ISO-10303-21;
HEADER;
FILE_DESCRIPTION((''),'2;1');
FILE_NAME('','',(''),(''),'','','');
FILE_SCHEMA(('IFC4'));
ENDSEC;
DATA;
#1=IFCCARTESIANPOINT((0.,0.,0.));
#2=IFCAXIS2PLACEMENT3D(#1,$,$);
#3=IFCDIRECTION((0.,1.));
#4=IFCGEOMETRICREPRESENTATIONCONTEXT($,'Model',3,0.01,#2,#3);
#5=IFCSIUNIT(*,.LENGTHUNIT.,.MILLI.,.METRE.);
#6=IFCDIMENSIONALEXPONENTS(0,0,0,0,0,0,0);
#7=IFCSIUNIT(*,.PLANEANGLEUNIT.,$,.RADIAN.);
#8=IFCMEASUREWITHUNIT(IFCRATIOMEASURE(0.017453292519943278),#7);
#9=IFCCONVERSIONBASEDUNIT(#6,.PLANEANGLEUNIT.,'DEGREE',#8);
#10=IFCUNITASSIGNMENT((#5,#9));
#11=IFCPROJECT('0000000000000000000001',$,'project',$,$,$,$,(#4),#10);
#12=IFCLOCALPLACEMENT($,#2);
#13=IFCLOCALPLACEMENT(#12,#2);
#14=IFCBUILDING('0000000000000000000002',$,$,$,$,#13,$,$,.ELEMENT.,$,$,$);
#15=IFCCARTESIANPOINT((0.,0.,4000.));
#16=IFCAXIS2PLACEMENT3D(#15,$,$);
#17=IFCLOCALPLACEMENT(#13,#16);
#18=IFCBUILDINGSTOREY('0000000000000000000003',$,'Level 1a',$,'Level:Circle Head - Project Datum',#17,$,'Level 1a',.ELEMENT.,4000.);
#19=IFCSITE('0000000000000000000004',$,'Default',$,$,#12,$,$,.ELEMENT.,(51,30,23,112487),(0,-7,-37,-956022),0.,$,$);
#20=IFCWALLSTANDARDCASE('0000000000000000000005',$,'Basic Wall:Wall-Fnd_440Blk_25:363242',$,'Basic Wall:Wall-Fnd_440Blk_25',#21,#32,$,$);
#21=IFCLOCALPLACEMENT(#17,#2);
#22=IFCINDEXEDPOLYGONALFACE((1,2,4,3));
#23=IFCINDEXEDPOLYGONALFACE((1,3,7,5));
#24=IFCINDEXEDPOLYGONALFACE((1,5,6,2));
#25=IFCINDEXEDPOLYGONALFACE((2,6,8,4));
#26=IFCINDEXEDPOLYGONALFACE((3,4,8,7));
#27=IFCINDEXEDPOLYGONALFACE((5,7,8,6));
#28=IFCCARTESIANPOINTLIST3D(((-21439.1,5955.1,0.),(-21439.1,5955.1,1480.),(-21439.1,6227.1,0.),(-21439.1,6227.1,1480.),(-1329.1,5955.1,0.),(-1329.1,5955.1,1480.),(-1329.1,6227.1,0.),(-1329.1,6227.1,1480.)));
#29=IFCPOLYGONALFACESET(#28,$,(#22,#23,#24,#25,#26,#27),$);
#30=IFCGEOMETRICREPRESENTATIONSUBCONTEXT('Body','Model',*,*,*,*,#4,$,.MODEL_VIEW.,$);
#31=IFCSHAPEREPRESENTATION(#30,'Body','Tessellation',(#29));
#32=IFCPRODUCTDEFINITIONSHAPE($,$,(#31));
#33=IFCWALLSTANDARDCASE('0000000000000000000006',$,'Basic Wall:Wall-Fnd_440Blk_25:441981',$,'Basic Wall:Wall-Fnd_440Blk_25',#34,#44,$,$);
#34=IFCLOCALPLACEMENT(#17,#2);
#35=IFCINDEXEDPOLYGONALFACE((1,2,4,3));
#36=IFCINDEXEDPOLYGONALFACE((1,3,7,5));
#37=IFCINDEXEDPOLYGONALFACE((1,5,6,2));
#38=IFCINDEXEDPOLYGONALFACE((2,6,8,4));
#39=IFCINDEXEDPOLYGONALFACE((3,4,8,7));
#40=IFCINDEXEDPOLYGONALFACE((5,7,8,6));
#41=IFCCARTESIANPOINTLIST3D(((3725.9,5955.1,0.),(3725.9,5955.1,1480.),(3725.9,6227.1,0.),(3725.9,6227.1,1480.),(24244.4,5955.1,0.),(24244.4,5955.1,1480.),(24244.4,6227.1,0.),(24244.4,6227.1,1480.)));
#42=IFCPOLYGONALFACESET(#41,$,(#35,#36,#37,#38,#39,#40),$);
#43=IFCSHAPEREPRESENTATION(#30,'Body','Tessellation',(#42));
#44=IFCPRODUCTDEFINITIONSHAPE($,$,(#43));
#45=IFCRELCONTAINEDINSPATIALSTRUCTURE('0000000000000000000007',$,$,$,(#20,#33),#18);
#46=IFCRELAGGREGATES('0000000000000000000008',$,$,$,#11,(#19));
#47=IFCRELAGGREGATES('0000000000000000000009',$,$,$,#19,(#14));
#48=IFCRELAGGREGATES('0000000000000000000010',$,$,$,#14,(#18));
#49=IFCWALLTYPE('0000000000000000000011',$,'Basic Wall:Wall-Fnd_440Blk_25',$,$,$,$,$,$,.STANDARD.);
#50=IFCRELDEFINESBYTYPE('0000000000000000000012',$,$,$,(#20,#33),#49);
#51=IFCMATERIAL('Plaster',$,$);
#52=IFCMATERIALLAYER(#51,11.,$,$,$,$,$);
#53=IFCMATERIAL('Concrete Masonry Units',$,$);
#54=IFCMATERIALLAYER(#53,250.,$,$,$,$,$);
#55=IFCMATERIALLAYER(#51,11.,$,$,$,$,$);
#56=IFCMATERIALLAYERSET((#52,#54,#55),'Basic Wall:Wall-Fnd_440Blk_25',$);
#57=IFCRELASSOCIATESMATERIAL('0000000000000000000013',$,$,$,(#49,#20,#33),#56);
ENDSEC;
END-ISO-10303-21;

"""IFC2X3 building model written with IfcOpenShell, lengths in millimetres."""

from ifc_helpers import new_model, entity, si_unit, converted_unit, direction, frame, frame_2d, origin, place, context, subcontext, project, spatial, rectangle, extrude, material, layer, layer_set, layer_usage, type_object, element, save


model = new_model("IFC2X3")

# Units and contexts
model_context = context("Model", 3, precision=0.01, world=origin(), true_north=direction((0.0, 1.0)))
body_context = subcontext(model_context, "Body", "Model", "MODEL_VIEW")
ifc_project = project(units=[si_unit("LENGTHUNIT", "METRE", prefix="MILLI"), converted_unit("PLANEANGLEUNIT", "DEGREE", entity("IfcRatioMeasure", 0.017453292519943278), si_unit("PLANEANGLEUNIT", "RADIAN"), dimensions=[0, 0, 0, 0, 0, 0, 0])], contexts=[model_context])

# Site, building, storey
site_placement = place(None, origin())
site = spatial("IfcSite", under=ifc_project, at=site_placement, Name="Default", CompositionType="ELEMENT", RefLatitude=(51, 30, 23, 112487), RefLongitude=(0, -7, -37, -956022), RefElevation=0.0)
building_placement = place(site_placement, origin())
building = spatial("IfcBuilding", under=site, at=building_placement, CompositionType="ELEMENT")
storey_placement = place(building_placement, frame((0.0, 0.0, 4000.0)))
storey = spatial("IfcBuildingStorey", under=building, at=storey_placement, Name="Level 1a", ObjectType="Level:Circle Head - Project Datum", LongName="Level 1a", CompositionType="ELEMENT", Elevation=4000.0)

# Walls
ifc_material_1 = material(Name="Plaster")
ifc_layer_1 = layer(ifc_material_1, 11.0)
ifc_material_2 = material(Name="Concrete Masonry Units")
ifc_layer_2 = layer(ifc_material_2, 250.0)
ifc_layer_3 = layer(ifc_material_1, 11.0)
ifc_layer_set = layer_set([ifc_layer_1, ifc_layer_2, ifc_layer_3], Name="Basic Wall:Wall-Fnd_440Blk_25")
ifc_layer_usage_1 = layer_usage(ifc_layer_set, "AXIS2", "NEGATIVE", 136.0)
wall_type = type_object("IfcWallType", Name="Basic Wall:Wall-Fnd_440Blk_25", PredefinedType="STANDARD", material=ifc_layer_set)
wall_1_placement = place(storey_placement, frame((-1329.1, 6091.1, 0.0), z_axis=(0.0, 0.0, 1.0), x_axis=(-1.0, 0.0, 0.0)))
element("IfcWallStandardCase", 1, at=wall_1_placement, inside=storey, type_object=wall_type, material=ifc_layer_usage_1, Name="Basic Wall:Wall-Fnd_440Blk_25:363242", ObjectType="Basic Wall:Wall-Fnd_440Blk_25", context=body_context, shape_type="SweptSolid", body=[
    extrude(rectangle(XDim=20110.0, YDim=272.0, at=frame_2d((10055.0, 0.0), x_axis=(-1.0, 0.0))), origin(), (0.0, 0.0, 1.0), 1480.0),
])
ifc_layer_usage_2 = layer_usage(ifc_layer_set, "AXIS2", "NEGATIVE", 136.0)
wall_2_placement = place(storey_placement, frame((24244.4, 6091.1, 0.0), z_axis=(0.0, 0.0, 1.0), x_axis=(-1.0, 0.0, 0.0)))
element("IfcWallStandardCase", 2, at=wall_2_placement, inside=storey, type_object=wall_type, material=ifc_layer_usage_2, Name="Basic Wall:Wall-Fnd_440Blk_25:441981", ObjectType="Basic Wall:Wall-Fnd_440Blk_25", context=body_context, shape_type="SweptSolid", body=[
    extrude(rectangle(XDim=20518.5, YDim=272.0, at=frame_2d((10259.3, 0.0), x_axis=(-1.0, 0.0))), origin(), (0.0, 0.0, 1.0), 1480.0),
])

save(model, "model.ifc")
